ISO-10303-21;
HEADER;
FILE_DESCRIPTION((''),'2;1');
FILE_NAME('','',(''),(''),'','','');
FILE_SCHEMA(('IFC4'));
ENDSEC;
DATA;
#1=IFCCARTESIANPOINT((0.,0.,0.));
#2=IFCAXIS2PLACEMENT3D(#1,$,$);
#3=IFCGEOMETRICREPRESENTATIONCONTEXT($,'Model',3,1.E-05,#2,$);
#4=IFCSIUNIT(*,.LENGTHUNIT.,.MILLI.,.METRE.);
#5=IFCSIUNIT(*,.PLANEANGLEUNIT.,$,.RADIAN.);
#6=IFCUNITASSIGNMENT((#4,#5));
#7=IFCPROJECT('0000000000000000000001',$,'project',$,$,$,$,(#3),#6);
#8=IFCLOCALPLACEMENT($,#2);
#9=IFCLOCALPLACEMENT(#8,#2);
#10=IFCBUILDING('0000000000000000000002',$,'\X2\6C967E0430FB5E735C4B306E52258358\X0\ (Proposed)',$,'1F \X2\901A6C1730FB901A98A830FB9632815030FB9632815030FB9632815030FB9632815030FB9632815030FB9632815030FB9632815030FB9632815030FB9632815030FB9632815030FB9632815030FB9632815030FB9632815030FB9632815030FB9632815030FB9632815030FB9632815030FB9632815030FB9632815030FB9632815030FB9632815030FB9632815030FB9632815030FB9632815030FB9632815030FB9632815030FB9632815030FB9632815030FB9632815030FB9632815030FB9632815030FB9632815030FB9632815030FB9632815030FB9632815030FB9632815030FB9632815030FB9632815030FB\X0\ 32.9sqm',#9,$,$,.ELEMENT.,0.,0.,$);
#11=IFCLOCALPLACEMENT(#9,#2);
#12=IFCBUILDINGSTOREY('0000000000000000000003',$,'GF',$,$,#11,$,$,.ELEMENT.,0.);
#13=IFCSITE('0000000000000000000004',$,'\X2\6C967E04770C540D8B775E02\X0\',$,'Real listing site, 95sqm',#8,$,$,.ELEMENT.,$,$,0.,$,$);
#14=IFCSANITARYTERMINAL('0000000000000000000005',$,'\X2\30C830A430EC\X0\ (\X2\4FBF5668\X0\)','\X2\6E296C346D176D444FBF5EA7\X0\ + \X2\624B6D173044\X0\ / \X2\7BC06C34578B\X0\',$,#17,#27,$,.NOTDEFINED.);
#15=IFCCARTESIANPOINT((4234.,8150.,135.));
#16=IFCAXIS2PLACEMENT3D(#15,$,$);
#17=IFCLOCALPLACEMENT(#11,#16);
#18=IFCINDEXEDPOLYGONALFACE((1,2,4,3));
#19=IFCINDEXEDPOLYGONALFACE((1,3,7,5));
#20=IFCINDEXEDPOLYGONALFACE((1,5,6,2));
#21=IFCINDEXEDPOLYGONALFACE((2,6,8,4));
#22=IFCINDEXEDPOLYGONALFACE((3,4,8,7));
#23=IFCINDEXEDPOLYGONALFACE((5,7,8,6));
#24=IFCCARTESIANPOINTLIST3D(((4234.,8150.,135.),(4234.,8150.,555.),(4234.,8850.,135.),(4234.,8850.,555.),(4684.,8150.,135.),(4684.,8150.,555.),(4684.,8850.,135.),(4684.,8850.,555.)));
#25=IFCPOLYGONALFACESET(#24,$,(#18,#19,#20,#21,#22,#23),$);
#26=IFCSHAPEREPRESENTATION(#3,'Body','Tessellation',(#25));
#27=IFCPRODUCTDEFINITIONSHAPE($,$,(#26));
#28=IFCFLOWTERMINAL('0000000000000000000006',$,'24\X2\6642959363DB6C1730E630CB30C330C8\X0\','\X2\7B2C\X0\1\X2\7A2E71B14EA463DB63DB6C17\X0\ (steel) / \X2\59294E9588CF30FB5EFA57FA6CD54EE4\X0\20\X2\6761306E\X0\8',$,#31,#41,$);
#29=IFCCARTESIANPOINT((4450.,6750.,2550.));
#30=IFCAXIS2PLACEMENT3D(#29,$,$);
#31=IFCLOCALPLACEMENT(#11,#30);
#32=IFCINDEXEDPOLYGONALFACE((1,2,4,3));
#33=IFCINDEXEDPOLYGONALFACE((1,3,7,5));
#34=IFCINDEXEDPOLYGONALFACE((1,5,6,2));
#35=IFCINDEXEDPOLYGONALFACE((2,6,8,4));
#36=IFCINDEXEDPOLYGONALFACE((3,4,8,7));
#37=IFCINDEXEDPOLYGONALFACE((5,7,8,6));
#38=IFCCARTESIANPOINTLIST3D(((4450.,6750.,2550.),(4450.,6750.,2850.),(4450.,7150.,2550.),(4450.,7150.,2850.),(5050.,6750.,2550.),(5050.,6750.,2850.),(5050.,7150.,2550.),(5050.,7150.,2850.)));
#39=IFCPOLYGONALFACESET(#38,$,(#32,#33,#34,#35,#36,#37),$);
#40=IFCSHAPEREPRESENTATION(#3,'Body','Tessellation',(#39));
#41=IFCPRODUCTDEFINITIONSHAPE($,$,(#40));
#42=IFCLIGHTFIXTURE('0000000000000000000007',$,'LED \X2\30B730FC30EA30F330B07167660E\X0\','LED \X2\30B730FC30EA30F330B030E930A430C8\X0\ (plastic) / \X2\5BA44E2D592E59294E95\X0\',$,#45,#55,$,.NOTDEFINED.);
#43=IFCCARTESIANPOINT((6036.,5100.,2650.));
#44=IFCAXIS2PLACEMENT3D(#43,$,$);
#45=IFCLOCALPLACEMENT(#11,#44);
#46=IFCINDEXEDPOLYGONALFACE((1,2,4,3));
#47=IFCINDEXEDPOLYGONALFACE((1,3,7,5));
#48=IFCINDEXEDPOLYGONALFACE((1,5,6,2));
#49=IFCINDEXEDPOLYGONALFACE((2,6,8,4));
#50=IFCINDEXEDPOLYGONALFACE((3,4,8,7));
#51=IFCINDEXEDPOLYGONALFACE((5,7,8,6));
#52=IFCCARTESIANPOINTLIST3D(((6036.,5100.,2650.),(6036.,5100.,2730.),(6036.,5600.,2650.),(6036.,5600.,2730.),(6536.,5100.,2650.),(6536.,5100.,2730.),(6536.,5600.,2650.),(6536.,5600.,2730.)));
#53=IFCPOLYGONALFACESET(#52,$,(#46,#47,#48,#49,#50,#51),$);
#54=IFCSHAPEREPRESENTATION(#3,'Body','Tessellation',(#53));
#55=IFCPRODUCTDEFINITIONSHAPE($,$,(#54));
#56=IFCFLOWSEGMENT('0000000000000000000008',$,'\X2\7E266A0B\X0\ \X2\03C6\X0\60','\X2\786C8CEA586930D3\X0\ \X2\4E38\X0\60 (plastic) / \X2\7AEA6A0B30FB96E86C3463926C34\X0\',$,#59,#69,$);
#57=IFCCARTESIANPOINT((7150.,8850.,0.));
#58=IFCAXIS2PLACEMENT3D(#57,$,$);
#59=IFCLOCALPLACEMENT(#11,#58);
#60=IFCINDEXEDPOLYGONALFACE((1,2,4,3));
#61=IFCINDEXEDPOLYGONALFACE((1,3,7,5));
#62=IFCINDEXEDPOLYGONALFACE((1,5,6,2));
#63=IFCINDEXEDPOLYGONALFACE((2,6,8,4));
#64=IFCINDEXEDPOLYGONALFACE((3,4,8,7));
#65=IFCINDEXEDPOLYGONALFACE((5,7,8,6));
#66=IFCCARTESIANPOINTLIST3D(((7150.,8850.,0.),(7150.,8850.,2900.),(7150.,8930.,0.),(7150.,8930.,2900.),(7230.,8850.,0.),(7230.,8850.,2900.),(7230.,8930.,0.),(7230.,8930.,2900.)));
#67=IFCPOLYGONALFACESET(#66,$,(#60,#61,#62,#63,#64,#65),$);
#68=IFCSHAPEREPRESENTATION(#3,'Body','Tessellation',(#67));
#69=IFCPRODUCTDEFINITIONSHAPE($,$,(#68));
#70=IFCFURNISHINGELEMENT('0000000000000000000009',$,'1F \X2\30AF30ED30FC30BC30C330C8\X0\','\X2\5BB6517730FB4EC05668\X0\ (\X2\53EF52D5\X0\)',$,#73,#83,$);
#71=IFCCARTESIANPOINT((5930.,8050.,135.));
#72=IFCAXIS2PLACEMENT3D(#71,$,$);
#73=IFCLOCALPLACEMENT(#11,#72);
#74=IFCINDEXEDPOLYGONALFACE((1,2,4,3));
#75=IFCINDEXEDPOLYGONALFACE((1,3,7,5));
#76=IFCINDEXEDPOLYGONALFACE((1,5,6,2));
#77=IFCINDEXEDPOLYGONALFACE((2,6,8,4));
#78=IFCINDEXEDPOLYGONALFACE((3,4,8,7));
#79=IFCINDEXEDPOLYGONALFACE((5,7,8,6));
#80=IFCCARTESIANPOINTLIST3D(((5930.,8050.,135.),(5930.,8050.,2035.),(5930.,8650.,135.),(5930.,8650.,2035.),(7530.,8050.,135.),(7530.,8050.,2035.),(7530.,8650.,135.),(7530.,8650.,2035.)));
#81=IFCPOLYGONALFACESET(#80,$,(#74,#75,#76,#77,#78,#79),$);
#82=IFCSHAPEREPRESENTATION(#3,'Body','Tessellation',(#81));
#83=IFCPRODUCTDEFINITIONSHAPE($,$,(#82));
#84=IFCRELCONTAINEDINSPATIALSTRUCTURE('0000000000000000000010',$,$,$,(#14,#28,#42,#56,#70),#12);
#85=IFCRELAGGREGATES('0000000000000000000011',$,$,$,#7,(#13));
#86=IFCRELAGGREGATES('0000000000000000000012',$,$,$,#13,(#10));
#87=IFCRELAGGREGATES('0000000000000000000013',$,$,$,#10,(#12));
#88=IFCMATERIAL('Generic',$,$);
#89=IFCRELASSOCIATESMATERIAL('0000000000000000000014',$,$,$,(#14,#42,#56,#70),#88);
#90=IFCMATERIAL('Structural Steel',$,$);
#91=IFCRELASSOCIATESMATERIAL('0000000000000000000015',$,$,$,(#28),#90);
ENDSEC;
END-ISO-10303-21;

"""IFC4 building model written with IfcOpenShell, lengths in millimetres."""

from ifc_helpers import new_model, si_unit, frame, frame_2d, origin, place, context, project, spatial, rectangle, extrude, material, element, save


model = new_model("IFC4")

# Units and contexts
model_context = context("Model", 3, precision=1e-05, world=origin())
ifc_project = project(units=[si_unit("LENGTHUNIT", "METRE", prefix="MILLI"), si_unit("PLANEANGLEUNIT", "RADIAN")], contexts=[model_context])

# Site, building, storey
site_placement = place(None, origin())
site = spatial("IfcSite", under=ifc_project, at=site_placement, Name="沖縄県名護市", ObjectType="Real listing site, 95sqm", CompositionType="ELEMENT", RefElevation=0.0)
building_placement = place(site_placement, origin())
building = spatial("IfcBuilding", under=site, at=building_placement, Name="沖縄・平屋の別荘 (Proposed)", ObjectType="1F 通気・通風・防腐・防腐・防腐・防腐・防腐・防腐・防腐・防腐・防腐・防腐・防腐・防腐・防腐・防腐・防腐・防腐・防腐・防腐・防腐・防腐・防腐・防腐・防腐・防腐・防腐・防腐・防腐・防腐・防腐・防腐・防腐・防腐・防腐・防腐・防腐・防腐・防腐・防腐・ 32.9sqm", CompositionType="ELEMENT", ElevationOfRefHeight=0.0, ElevationOfTerrain=0.0)
storey_placement = place(building_placement, origin())
storey = spatial("IfcBuildingStorey", under=building, at=storey_placement, Name="GF", CompositionType="ELEMENT", Elevation=0.0)

# Shared definitions
ifc_material_1 = material(Name="Generic")

# Sanitary terminal
sanitary_terminal_1_placement = place(storey_placement, frame((4234.0, 8150.0, 135.0)))
element("IfcSanitaryTerminal", 1, at=sanitary_terminal_1_placement, inside=storey, material=ifc_material_1, Name="トイレ (便器)", Description="温水洗浄便座 + 手洗い / 節水型", PredefinedType="NOTDEFINED", context=model_context, shape_type="SweptSolid", body=[
    extrude(rectangle(XDim=450.0, YDim=700.0, at=frame_2d((225.0, 350.0))), frame((4234.0, 8150.0, 135.0)), (0.0, 0.0, 1.0), 420.0),
])

# Flow terminal
ifc_material_2 = material(Name="Structural Steel")
flow_terminal_placement = place(storey_placement, frame((4450.0, 6750.0, 2550.0)))
element("IfcFlowTerminal", 2, at=flow_terminal_placement, inside=storey, material=ifc_material_2, Name="24時間換気ユニット", Description="第1種熱交換換気 (steel) / 天井裏・建基法令20条の8", context=model_context, shape_type="SweptSolid", body=[
    extrude(rectangle(XDim=600.0, YDim=400.0, at=frame_2d((300.0, 200.0))), frame((4450.0, 6750.0, 2550.0)), (0.0, 0.0, 1.0), 300.0),
])

# Light fixture
light_fixture_placement = place(storey_placement, frame((6036.0, 5100.0, 2650.0)))
element("IfcLightFixture", 3, at=light_fixture_placement, inside=storey, material=ifc_material_1, Name="LED シーリング照明", Description="LED シーリングライト (plastic) / 室中央天井", PredefinedType="NOTDEFINED", context=model_context, shape_type="SweptSolid", body=[
    extrude(rectangle(XDim=500.0, YDim=500.0, at=frame_2d((250.0, 250.0))), frame((6036.0, 5100.0, 2650.0)), (0.0, 0.0, 1.0), 80.0),
])

# Flow segment
flow_segment_placement = place(storey_placement, frame((7150.0, 8850.0, 0.0)))
element("IfcFlowSegment", 4, at=flow_segment_placement, inside=storey, material=ifc_material_1, Name="縦樋 φ60", Description="硬質塩ビ 丸60 (plastic) / 竪樋・雨水排水", context=model_context, shape_type="SweptSolid", body=[
    extrude(rectangle(XDim=80.0, YDim=80.0, at=frame_2d((40.0, 40.0))), frame((7150.0, 8850.0, 0.0)), (0.0, 0.0, 1.0), 2900.0),
])

# Furnishing element
furnishing_placement = place(storey_placement, frame((5930.0, 8050.0, 135.0)))
element("IfcFurnishingElement", 5, at=furnishing_placement, inside=storey, material=ifc_material_1, Name="1F クローゼット", Description="家具・什器 (可動)", context=model_context, shape_type="SweptSolid", body=[
    extrude(rectangle(XDim=1600.0, YDim=600.0, at=frame_2d((800.0, 300.0))), frame((5930.0, 8050.0, 135.0)), (0.0, 0.0, 1.0), 1900.0),
])

save(model, "model.ifc")
